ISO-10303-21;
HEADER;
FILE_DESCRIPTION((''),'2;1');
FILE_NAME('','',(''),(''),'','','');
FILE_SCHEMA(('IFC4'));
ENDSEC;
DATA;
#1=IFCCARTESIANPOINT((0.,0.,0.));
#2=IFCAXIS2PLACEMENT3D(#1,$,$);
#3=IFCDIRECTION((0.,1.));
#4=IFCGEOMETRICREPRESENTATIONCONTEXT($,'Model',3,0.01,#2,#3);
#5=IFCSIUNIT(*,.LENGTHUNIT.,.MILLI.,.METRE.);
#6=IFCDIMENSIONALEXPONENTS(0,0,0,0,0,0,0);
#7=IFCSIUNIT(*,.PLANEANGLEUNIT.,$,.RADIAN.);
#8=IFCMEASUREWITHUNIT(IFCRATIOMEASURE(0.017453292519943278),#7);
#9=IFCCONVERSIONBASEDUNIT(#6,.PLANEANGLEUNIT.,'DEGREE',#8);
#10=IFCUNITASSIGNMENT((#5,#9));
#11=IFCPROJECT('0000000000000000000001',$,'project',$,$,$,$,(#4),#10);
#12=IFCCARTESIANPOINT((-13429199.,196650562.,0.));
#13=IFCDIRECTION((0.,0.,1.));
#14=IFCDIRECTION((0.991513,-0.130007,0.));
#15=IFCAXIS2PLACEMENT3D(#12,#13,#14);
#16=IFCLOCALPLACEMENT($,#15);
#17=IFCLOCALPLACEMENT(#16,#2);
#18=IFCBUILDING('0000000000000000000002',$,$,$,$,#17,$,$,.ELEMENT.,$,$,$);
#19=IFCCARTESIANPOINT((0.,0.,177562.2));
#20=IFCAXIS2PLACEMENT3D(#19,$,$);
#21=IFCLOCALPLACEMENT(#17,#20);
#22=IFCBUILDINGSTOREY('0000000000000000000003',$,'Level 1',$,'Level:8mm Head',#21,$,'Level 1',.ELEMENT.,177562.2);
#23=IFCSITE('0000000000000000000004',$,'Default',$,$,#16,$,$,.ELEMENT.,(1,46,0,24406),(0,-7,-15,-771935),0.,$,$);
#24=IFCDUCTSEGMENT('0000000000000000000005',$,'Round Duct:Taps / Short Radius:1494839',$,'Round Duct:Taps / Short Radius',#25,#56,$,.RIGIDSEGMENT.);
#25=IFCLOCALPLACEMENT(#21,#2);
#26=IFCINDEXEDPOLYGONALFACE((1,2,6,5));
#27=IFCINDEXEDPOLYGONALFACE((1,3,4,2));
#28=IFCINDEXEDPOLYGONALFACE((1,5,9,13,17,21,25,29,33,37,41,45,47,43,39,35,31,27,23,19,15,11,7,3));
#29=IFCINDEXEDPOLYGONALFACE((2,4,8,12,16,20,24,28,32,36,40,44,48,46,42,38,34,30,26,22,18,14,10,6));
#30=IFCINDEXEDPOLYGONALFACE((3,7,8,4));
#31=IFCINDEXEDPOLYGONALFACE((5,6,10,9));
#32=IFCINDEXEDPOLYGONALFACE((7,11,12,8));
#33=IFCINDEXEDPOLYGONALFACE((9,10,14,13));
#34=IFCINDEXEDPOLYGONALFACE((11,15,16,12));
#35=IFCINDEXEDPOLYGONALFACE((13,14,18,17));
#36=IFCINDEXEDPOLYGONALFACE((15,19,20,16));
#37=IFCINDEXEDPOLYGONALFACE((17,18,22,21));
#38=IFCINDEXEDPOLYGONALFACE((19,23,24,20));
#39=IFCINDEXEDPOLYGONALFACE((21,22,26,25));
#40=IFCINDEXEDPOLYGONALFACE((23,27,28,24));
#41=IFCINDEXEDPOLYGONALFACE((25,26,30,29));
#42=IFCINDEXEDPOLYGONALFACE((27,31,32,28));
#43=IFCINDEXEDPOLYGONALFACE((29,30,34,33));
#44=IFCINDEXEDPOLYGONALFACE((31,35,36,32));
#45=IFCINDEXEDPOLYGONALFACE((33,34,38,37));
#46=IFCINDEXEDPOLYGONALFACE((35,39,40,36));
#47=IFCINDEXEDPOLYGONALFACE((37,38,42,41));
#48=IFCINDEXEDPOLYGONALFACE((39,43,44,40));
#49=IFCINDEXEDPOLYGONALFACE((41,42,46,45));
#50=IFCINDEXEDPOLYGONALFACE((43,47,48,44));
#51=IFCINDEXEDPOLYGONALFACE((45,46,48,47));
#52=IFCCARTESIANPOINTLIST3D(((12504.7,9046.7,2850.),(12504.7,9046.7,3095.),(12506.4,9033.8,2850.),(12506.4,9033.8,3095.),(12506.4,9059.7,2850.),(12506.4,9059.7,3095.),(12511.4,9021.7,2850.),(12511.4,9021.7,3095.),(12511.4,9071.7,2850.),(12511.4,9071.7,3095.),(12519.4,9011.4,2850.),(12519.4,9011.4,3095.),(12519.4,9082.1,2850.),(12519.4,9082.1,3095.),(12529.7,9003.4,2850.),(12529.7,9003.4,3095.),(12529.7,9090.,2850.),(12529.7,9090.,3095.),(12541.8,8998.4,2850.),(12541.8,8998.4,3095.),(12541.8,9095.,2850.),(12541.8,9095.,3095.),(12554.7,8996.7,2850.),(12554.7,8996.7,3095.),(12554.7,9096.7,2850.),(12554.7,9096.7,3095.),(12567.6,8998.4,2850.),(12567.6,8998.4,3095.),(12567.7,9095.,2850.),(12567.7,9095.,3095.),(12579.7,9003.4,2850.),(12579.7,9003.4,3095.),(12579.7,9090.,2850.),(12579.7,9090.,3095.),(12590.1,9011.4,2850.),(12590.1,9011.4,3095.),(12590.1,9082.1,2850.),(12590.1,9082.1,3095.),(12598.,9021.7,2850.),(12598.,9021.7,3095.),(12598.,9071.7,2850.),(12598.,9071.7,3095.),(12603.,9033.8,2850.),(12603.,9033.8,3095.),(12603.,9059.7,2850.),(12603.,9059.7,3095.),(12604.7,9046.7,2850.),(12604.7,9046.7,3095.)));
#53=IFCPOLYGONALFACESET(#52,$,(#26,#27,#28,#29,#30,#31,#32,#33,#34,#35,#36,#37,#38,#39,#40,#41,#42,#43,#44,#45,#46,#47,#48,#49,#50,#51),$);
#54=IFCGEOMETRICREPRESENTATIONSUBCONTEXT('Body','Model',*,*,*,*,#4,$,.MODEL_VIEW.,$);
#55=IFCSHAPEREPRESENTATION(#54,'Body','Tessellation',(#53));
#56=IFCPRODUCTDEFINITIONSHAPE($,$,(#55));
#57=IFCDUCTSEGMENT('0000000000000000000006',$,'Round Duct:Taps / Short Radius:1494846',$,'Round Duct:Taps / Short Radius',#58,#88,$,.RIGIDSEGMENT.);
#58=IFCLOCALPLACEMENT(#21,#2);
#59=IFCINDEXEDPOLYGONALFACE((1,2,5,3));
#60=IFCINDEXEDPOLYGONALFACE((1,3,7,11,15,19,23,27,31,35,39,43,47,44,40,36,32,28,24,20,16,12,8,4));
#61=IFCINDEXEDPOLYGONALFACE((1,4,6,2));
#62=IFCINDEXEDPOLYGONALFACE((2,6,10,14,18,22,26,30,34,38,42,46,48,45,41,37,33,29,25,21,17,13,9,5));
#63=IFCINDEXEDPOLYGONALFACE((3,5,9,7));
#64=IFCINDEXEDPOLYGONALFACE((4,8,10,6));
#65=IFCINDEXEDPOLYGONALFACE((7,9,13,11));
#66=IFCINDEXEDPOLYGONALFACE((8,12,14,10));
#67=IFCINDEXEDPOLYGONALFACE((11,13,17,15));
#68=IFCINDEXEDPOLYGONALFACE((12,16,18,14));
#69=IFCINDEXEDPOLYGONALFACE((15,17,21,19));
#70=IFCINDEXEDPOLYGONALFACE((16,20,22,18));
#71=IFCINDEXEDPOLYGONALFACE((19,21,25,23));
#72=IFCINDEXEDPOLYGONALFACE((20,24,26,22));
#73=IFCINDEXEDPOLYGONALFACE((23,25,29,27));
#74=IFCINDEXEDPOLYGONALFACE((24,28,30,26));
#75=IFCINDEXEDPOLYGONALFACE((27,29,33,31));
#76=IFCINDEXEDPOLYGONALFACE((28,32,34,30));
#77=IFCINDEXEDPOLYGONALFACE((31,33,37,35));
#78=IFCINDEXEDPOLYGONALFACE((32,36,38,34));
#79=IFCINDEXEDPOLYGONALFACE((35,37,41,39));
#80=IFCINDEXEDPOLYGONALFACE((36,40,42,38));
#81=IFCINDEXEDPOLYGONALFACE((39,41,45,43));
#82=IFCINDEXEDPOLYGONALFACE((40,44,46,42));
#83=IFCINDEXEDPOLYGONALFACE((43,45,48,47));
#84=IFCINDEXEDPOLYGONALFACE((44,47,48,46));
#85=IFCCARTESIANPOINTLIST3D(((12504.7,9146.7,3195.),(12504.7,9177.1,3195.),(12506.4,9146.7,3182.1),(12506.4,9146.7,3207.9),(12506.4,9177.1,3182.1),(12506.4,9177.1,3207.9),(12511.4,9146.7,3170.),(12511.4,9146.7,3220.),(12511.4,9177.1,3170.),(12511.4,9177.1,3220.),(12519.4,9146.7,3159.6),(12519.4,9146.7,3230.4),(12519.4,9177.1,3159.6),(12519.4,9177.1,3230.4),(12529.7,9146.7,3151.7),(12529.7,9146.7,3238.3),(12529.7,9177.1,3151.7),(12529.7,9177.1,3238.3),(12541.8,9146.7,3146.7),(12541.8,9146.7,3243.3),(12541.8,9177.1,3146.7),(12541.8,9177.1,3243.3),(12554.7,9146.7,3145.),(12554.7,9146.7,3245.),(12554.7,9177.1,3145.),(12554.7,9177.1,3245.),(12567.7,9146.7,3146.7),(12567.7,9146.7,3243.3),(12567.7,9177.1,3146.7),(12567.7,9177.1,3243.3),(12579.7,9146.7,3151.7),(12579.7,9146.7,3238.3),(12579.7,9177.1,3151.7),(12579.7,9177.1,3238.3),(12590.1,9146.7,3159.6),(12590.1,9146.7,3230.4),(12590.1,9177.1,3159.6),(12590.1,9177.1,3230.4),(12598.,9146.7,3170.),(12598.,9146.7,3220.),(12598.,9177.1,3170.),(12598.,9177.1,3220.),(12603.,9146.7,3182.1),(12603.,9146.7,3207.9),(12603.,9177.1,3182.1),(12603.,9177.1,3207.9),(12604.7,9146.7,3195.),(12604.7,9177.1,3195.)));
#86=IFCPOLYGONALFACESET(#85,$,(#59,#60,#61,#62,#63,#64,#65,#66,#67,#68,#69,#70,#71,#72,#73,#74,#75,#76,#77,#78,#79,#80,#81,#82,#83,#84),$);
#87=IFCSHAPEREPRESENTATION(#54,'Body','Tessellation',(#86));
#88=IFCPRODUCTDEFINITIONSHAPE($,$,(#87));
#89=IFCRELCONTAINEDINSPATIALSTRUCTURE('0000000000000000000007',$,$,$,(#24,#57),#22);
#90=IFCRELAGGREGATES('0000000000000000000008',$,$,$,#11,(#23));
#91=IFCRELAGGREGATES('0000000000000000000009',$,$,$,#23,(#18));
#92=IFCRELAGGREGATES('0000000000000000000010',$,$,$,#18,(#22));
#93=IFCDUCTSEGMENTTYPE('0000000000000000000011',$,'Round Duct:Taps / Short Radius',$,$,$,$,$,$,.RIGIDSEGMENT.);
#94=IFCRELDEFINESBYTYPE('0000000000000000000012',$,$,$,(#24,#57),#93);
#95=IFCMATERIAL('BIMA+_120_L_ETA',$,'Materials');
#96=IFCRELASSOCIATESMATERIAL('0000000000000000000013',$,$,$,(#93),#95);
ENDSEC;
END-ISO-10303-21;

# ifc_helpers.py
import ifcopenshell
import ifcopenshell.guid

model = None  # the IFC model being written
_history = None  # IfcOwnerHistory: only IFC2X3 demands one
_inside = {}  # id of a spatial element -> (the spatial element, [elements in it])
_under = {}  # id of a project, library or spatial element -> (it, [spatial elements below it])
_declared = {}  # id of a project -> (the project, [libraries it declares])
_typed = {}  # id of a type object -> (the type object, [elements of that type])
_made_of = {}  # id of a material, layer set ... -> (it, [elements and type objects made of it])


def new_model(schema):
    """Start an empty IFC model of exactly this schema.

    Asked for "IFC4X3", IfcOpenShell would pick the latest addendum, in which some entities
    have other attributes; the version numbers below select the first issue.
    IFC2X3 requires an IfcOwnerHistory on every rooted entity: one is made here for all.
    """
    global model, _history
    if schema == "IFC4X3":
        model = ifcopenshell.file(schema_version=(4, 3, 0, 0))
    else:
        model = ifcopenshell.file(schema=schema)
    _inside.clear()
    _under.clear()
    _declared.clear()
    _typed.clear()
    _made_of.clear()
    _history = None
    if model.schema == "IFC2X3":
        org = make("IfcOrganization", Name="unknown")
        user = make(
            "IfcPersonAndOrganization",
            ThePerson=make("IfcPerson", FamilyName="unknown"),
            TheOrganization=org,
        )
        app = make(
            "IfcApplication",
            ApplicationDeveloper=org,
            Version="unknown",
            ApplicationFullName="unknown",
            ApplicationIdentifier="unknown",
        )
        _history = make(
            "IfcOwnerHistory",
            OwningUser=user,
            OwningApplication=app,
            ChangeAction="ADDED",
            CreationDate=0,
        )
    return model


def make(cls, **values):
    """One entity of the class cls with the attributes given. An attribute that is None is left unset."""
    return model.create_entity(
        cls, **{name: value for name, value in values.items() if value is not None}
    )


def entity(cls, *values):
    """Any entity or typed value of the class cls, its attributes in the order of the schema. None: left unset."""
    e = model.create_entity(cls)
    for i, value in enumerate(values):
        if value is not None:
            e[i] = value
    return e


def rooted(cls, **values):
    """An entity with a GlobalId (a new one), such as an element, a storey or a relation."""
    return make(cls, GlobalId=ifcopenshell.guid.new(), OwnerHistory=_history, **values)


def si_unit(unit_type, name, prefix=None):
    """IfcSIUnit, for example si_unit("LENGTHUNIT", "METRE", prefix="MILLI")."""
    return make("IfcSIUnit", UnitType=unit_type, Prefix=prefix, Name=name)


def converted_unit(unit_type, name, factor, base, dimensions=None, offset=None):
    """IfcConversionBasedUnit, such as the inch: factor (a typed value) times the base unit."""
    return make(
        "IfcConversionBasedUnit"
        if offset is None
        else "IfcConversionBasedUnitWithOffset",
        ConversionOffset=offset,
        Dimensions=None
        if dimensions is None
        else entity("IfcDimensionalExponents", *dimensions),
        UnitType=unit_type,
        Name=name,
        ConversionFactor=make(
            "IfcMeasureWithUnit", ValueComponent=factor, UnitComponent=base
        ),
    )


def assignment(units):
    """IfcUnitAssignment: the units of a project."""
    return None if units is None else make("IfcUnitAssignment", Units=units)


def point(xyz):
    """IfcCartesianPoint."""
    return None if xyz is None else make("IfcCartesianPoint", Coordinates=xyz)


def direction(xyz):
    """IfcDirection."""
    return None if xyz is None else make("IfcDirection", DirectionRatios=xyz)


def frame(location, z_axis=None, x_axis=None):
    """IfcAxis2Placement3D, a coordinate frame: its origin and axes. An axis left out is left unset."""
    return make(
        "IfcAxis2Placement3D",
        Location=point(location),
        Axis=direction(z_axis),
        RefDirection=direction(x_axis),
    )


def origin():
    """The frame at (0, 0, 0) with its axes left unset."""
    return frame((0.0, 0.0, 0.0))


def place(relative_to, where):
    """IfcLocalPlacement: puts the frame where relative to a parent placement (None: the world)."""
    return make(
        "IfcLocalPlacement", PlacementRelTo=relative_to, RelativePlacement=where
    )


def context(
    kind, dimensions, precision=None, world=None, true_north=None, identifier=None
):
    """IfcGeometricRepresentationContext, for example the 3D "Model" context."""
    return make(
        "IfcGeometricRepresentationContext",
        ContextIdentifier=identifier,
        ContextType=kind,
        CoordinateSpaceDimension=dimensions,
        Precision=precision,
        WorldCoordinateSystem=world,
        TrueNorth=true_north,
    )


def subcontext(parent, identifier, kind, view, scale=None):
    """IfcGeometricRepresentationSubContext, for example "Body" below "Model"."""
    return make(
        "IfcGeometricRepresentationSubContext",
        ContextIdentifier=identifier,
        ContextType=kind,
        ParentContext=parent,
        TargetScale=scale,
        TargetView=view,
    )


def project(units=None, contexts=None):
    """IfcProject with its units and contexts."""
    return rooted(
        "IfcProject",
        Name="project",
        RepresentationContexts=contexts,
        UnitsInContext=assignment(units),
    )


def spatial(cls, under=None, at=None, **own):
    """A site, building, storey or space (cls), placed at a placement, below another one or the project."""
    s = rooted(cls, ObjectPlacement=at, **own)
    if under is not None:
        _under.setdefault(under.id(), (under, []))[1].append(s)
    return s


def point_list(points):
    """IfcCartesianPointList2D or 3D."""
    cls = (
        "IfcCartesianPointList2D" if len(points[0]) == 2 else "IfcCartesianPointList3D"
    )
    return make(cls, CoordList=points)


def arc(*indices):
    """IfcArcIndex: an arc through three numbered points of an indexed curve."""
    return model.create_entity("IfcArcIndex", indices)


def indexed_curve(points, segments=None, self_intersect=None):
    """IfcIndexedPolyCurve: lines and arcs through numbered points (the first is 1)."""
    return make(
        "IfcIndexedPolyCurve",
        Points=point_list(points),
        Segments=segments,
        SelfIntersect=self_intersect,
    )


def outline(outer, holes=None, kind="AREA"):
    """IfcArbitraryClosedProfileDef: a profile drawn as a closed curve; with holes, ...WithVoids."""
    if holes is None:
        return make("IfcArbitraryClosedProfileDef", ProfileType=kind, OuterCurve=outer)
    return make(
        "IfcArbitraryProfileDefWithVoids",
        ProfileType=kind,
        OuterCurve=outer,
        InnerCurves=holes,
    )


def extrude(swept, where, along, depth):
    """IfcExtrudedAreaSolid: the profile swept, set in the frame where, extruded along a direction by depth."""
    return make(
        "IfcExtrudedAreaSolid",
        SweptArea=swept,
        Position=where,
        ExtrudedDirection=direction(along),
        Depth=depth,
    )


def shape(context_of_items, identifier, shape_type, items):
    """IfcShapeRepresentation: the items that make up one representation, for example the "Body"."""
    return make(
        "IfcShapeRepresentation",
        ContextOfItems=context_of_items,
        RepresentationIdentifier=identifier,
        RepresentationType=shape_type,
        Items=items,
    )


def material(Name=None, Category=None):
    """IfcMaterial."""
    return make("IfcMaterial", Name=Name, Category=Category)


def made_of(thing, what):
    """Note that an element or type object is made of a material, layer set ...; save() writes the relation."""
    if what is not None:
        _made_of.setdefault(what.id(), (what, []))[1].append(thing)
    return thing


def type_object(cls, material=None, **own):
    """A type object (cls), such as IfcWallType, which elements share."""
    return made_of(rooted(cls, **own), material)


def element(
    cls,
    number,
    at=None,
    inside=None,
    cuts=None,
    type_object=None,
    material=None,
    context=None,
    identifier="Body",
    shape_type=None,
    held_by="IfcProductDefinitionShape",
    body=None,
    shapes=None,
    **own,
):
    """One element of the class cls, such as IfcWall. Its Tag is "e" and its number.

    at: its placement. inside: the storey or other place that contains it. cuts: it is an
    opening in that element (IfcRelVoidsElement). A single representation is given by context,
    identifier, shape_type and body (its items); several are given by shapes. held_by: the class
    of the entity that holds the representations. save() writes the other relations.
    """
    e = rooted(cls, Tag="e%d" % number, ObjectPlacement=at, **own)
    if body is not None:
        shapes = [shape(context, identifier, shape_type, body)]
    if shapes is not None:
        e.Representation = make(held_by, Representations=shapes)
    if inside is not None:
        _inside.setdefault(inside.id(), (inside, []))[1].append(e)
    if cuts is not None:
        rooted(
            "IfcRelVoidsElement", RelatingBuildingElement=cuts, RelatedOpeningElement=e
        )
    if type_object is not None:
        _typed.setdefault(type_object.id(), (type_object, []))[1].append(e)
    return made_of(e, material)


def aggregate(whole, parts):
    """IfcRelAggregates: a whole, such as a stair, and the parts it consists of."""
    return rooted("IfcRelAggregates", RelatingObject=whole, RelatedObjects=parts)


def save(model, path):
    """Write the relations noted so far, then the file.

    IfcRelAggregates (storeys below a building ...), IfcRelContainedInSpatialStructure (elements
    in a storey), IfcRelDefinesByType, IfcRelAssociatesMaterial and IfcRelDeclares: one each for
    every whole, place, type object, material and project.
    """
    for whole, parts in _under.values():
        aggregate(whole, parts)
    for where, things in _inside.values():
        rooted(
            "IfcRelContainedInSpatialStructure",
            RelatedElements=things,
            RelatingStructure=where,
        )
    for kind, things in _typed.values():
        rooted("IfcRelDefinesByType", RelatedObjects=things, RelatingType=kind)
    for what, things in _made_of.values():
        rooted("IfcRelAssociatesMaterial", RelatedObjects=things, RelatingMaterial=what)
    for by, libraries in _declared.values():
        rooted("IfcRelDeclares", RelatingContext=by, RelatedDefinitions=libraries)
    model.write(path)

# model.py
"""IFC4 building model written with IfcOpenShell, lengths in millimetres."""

from ifc_helpers import new_model, entity, si_unit, converted_unit, direction, frame, origin, place, context, subcontext, project, spatial, arc, indexed_curve, outline, extrude, material, type_object, element, save


model = new_model("IFC4")

# Units and contexts
model_context = context("Model", 3, precision=0.01, world=origin(), true_north=direction((0.0, 1.0)))
body_context = subcontext(model_context, "Body", "Model", "MODEL_VIEW")
ifc_project = project(units=[si_unit("LENGTHUNIT", "METRE", prefix="MILLI"), converted_unit("PLANEANGLEUNIT", "DEGREE", entity("IfcRatioMeasure", 0.017453292519943278), si_unit("PLANEANGLEUNIT", "RADIAN"), dimensions=[0, 0, 0, 0, 0, 0, 0])], contexts=[model_context])

# Site, building, storey
site_placement = place(None, frame((-13429199.0, 196650562.0, 0.0), z_axis=(0.0, 0.0, 1.0), x_axis=(0.991513, -0.130007, 0.0)))
site = spatial("IfcSite", under=ifc_project, at=site_placement, Name="Default", CompositionType="ELEMENT", RefLatitude=(1, 46, 0, 24406), RefLongitude=(0, -7, -15, -771935), RefElevation=0.0)
building_placement = place(site_placement, origin())
building = spatial("IfcBuilding", under=site, at=building_placement, CompositionType="ELEMENT")
storey_placement = place(building_placement, frame((0.0, 0.0, 177562.2)))
storey = spatial("IfcBuildingStorey", under=building, at=storey_placement, Name="Level 1", ObjectType="Level:8mm Head", LongName="Level 1", CompositionType="ELEMENT", Elevation=177562.2)

# Duct segments
ifc_material_1 = material(Name="BIMA+_120_L_ETA", Category="Materials")
duct_segment_type = type_object("IfcDuctSegmentType", Name="Round Duct:Taps / Short Radius", PredefinedType="RIGIDSEGMENT", material=ifc_material_1)
duct_segment_1_placement = place(storey_placement, frame((12503.1, 8995.1, 3095.0)))
element("IfcDuctSegment", 1, at=duct_segment_1_placement, inside=storey, type_object=duct_segment_type, Name="Round Duct:Taps / Short Radius:1494839", ObjectType="Round Duct:Taps / Short Radius", PredefinedType="RIGIDSEGMENT", context=body_context, shape_type="SweptSolid", body=[
    extrude(outline(indexed_curve([(50.0, 0.0), (35.4, 35.4), (0.0, 50.0), (-35.4, 35.4), (-50.0, 0.0), (-35.4, -35.4), (0.0, -50.0), (35.4, -35.4)], segments=[arc(1, 2, 3), arc(3, 4, 5), arc(5, 6, 7), arc(7, 8, 1)], self_intersect=False)), frame((51.6, 51.6, -245.0), z_axis=(0.0, 0.0, 1.0), x_axis=(-1.0, 0.000125, 0.0)), (0.0, 0.0, 1.0), 245.0),
])
duct_segment_2_placement = place(storey_placement, frame((12503.1, 9146.7, 3143.4)))
element("IfcDuctSegment", 2, at=duct_segment_2_placement, inside=storey, type_object=duct_segment_type, Name="Round Duct:Taps / Short Radius:1494846", ObjectType="Round Duct:Taps / Short Radius", PredefinedType="RIGIDSEGMENT", context=body_context, shape_type="SweptSolid", body=[
    extrude(outline(indexed_curve([(50.0, 0.0), (35.4, 35.4), (0.0, 50.0), (-35.4, 35.4), (-50.0, 0.0), (-35.4, -35.4), (0.0, -50.0), (35.4, -35.4)], segments=[arc(1, 2, 3), arc(3, 4, 5), arc(5, 6, 7), arc(7, 8, 1)], self_intersect=False)), frame((51.6, 0.0, 51.6), z_axis=(0.000125, 1.0, 0.0), x_axis=(-1.0, 0.000125, 0.0)), (0.0, 0.0, 1.0), 30.4),
])

save(model, "model.ifc")
